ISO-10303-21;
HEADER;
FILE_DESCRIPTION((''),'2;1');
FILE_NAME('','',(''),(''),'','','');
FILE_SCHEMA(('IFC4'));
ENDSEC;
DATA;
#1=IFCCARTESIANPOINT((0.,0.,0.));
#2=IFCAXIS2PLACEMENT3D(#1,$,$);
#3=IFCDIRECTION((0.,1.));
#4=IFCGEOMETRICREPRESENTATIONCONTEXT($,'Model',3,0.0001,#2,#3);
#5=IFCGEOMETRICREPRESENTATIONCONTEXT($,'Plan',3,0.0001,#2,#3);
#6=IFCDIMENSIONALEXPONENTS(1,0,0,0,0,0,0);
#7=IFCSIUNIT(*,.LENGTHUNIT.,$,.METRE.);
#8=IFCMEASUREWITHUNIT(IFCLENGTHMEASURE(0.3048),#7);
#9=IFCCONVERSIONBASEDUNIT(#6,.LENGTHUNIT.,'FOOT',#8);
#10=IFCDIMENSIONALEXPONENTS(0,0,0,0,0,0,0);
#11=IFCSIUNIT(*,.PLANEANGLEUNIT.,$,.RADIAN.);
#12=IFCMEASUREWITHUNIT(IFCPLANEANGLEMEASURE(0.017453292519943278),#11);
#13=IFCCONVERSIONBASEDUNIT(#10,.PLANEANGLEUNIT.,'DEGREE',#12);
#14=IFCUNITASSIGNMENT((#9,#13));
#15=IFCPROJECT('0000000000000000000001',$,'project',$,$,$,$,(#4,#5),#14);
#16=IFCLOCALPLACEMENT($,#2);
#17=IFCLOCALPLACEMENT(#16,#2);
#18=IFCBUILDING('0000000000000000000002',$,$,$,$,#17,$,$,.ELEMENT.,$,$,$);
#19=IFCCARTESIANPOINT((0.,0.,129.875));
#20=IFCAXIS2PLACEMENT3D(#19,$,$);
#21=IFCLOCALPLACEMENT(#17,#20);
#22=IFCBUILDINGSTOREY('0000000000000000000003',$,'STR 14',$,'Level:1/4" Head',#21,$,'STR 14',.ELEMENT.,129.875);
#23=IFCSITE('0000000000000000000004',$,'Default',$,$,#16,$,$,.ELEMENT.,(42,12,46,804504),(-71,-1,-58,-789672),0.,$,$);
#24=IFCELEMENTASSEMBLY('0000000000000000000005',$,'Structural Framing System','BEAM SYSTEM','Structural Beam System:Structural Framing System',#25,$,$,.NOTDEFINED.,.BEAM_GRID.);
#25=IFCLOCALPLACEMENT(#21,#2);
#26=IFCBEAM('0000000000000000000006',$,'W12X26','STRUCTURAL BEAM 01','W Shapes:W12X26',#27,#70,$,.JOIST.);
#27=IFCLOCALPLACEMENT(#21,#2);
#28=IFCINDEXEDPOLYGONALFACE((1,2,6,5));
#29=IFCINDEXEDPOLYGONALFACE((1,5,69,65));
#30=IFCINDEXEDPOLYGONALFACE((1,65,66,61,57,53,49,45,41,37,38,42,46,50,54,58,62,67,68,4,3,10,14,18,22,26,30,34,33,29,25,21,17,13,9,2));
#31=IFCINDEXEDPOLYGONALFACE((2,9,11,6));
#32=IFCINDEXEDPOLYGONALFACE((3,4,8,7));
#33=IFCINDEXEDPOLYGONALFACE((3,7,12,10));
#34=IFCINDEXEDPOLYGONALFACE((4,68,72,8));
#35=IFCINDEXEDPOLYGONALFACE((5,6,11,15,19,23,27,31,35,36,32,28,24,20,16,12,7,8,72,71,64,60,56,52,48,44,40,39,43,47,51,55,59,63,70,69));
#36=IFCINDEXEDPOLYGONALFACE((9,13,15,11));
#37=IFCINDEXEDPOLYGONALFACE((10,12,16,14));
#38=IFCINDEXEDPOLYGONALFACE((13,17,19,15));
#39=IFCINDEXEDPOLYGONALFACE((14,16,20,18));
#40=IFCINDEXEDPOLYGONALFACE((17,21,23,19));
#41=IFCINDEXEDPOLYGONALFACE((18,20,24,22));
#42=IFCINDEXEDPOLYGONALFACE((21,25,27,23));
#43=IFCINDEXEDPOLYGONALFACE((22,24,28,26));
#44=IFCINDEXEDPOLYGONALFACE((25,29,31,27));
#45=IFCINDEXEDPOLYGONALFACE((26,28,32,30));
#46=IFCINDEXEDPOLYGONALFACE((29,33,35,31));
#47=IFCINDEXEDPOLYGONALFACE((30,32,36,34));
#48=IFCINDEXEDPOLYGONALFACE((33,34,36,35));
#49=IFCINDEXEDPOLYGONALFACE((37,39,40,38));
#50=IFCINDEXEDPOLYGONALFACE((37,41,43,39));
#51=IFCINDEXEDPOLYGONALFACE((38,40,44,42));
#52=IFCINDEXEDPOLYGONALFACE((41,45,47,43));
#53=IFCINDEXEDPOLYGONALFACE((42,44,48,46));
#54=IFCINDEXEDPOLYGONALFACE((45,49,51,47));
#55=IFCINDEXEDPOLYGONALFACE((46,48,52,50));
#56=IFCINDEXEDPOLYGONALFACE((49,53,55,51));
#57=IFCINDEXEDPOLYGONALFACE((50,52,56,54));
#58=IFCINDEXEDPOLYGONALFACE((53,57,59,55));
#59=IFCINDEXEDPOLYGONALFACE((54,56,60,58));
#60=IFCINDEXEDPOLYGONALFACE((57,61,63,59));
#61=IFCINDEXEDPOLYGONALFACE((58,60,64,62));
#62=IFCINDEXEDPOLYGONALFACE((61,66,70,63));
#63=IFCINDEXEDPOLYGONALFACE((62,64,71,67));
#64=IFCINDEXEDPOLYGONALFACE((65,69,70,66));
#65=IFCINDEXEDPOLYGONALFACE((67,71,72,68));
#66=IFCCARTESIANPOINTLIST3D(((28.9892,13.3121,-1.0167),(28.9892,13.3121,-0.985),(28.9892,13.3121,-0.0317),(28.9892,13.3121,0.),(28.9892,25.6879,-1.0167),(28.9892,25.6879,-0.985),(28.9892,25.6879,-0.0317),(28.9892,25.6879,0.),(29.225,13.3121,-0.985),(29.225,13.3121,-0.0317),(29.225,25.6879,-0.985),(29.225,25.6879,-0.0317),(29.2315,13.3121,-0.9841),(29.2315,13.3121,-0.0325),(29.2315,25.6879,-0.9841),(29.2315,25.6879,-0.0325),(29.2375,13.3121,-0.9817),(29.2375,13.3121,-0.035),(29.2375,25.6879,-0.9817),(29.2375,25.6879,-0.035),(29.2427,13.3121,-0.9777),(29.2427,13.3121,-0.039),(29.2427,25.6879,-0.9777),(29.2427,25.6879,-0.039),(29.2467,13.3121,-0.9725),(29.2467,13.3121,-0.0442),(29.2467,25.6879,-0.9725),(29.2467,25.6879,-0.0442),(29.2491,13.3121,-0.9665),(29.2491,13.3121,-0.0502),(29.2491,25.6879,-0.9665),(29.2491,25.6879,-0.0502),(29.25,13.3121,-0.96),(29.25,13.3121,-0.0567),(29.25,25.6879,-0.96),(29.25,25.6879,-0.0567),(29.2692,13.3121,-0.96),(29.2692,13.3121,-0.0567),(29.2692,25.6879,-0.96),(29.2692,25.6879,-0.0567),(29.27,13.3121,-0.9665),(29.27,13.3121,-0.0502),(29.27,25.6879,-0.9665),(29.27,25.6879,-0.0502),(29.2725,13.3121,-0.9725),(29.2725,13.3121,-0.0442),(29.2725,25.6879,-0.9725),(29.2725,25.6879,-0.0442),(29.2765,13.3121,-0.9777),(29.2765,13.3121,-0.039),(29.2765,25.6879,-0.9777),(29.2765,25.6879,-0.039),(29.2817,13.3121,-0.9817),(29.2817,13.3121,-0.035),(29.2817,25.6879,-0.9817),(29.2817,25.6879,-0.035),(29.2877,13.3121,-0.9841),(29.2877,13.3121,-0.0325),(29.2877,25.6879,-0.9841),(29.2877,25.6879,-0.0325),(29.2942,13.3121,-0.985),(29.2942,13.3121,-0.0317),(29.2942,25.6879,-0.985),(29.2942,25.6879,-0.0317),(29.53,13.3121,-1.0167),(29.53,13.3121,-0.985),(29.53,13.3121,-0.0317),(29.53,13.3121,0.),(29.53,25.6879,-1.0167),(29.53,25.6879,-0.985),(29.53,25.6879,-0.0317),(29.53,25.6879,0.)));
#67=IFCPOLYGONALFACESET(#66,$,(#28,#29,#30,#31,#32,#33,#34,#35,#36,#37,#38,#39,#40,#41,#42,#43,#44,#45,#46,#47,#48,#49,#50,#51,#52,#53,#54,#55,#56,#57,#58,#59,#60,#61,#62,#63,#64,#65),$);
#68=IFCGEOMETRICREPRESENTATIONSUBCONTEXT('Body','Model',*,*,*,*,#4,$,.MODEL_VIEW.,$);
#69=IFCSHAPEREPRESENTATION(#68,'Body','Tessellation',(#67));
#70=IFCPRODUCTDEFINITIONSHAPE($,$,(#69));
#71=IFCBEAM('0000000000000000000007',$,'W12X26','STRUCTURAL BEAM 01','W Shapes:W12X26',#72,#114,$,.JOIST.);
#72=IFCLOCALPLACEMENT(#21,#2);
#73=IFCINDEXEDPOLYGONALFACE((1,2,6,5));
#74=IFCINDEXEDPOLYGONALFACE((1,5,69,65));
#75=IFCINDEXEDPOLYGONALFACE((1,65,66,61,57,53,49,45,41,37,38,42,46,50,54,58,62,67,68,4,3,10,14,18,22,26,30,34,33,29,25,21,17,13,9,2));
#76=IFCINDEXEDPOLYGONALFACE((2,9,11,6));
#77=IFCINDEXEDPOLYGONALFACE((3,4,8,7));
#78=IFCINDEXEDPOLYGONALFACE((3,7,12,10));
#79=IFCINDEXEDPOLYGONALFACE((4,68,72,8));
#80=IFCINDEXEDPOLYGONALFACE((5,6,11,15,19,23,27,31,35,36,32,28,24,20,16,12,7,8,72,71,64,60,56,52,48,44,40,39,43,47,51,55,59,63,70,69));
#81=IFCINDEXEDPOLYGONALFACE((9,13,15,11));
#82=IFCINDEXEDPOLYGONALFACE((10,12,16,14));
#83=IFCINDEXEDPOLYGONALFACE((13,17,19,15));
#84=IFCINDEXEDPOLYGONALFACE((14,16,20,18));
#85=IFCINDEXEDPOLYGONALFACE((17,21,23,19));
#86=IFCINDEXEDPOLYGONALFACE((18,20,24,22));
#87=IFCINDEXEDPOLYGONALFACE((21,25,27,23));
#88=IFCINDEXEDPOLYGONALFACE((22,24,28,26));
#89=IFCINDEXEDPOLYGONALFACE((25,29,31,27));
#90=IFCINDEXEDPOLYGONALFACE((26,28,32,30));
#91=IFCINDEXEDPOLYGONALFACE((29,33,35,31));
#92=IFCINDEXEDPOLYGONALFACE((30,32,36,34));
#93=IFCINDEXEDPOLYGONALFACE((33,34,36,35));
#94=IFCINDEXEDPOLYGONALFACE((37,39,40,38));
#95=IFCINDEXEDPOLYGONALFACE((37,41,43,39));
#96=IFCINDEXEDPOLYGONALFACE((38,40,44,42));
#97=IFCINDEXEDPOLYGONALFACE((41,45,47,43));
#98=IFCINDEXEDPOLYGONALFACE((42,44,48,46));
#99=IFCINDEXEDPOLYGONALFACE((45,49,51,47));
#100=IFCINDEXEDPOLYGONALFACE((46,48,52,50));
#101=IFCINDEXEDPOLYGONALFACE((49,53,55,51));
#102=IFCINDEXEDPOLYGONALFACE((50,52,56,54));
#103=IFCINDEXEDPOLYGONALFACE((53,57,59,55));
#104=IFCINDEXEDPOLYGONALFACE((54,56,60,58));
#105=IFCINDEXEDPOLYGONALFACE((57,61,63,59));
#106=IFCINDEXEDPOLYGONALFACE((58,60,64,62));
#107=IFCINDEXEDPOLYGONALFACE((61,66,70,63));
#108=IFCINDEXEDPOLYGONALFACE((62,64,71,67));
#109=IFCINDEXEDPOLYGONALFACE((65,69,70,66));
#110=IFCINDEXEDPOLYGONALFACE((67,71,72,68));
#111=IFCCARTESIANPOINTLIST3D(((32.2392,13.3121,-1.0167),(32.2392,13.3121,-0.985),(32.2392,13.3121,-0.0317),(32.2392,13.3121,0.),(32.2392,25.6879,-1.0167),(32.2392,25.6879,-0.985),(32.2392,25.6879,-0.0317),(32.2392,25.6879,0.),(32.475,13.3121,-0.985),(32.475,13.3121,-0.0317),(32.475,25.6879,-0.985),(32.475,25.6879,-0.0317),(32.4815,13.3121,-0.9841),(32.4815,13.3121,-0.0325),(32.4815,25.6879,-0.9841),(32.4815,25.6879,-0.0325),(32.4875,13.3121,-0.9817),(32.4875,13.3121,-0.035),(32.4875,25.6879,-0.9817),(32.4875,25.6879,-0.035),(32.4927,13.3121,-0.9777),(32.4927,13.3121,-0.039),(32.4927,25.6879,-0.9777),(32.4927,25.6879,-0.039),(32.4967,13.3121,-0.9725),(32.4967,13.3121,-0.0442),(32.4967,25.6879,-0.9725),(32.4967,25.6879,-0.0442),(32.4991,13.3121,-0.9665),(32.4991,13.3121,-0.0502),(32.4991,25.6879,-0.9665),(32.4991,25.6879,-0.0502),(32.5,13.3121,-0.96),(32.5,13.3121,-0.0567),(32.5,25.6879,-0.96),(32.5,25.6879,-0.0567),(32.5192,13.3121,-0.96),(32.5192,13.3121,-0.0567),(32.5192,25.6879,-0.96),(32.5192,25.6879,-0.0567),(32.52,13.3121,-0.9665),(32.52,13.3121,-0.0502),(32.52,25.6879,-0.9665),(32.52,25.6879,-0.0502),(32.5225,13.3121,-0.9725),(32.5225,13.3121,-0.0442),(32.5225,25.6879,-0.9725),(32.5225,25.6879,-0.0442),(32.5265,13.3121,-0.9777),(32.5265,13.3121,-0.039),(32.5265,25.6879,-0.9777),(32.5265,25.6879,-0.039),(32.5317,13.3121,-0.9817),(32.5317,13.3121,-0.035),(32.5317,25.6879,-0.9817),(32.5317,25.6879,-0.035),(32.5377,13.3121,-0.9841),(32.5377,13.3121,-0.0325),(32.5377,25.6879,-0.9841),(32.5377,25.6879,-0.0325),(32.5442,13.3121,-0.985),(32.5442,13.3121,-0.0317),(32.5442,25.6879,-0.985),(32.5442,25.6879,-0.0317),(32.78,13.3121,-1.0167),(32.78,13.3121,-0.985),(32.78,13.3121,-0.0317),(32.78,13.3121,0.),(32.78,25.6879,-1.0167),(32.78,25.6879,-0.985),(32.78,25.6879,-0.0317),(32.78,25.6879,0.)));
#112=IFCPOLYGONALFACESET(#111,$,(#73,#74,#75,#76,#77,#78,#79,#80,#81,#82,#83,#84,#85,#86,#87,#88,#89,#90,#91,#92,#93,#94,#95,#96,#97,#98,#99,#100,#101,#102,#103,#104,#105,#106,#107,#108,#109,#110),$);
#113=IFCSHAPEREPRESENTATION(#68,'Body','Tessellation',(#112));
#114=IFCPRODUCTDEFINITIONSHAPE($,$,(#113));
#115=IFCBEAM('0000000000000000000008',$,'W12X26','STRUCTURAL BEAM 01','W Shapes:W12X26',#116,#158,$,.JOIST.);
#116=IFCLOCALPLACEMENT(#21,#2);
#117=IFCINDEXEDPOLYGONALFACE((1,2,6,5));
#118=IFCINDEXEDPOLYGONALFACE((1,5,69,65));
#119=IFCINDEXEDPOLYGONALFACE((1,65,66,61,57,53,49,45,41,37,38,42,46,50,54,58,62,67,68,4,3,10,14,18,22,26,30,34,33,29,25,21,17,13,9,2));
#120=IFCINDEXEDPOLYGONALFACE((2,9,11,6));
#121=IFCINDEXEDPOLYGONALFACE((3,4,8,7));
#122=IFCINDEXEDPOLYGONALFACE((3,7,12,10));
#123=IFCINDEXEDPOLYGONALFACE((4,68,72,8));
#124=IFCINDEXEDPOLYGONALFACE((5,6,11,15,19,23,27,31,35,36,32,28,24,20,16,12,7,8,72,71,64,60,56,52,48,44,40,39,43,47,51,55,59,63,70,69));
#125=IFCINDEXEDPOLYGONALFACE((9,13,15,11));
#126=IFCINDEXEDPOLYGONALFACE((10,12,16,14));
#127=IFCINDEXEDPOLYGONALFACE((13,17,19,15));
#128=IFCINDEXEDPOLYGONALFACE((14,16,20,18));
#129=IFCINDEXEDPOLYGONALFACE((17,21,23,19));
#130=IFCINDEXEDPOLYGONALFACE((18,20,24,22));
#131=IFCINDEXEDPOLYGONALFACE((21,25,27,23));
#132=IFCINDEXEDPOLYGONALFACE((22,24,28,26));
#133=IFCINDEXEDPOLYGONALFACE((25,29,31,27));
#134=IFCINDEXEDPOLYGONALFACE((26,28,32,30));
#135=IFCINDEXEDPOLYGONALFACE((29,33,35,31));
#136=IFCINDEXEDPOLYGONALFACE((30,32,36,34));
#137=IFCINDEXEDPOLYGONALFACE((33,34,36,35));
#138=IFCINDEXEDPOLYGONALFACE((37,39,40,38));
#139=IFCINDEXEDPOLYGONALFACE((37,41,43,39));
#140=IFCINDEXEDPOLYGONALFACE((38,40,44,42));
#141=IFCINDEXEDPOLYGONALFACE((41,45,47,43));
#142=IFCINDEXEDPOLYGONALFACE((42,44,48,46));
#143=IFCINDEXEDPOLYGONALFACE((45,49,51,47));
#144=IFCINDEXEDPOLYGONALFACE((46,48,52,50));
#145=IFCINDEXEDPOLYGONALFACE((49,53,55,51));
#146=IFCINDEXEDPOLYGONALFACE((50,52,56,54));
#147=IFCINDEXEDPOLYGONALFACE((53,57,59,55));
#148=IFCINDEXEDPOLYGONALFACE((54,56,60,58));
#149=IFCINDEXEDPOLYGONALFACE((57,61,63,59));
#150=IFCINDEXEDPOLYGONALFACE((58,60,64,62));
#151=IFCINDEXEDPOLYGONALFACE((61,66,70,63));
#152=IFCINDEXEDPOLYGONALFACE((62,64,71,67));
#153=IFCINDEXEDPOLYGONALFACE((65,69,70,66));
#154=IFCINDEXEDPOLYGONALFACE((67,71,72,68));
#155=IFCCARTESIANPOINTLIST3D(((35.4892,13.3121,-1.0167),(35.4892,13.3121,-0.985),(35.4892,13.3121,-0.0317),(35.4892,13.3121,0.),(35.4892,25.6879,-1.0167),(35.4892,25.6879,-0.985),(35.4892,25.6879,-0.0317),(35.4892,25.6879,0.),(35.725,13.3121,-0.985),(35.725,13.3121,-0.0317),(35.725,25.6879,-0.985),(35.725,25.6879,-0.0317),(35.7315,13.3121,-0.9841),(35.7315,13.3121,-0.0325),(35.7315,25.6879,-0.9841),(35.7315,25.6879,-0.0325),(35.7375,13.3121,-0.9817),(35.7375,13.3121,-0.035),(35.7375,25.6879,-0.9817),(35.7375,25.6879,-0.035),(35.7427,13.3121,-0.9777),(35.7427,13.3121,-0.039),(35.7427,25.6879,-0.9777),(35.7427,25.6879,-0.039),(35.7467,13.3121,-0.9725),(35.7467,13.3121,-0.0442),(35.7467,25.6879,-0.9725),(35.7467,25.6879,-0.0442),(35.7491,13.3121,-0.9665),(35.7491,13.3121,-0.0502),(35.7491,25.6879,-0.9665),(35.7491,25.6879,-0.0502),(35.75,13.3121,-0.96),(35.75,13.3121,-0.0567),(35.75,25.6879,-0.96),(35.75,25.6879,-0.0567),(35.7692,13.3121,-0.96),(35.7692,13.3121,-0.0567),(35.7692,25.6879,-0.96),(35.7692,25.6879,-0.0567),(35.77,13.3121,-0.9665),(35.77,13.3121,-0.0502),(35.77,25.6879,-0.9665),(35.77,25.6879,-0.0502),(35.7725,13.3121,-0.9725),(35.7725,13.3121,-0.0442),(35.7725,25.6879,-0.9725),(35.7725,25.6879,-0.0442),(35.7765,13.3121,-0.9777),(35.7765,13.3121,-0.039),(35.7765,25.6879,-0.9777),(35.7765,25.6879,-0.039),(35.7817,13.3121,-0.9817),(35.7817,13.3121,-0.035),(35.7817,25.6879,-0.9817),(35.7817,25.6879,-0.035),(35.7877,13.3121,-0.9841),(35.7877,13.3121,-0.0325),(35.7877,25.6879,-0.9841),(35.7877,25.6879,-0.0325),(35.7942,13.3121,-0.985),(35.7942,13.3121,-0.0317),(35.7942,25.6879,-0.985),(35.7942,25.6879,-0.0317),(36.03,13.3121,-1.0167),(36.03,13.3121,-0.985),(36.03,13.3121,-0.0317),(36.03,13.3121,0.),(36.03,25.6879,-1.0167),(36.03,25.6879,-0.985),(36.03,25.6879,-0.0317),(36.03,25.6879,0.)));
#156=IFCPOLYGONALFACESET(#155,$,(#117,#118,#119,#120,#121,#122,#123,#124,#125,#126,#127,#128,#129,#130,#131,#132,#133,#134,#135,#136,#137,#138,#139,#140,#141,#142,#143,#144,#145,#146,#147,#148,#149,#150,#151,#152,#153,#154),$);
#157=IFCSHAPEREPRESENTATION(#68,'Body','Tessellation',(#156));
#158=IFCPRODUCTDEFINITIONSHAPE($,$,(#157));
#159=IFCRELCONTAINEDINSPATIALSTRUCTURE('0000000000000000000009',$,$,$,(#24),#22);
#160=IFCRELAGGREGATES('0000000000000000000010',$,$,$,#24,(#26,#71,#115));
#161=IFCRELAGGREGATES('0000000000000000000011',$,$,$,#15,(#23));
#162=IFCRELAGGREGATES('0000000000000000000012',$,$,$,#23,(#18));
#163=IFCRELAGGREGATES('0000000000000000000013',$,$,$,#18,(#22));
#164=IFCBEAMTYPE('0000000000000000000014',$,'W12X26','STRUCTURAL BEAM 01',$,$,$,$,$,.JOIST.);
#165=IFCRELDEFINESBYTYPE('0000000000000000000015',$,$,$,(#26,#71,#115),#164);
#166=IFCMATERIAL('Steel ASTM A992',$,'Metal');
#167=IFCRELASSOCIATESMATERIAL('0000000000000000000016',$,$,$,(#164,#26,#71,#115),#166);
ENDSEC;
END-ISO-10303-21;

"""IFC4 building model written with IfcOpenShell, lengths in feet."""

from ifc_helpers import new_model, entity, si_unit, converted_unit, direction, frame, origin, place, context, subcontext, project, spatial, line, arc, indexed_curve, outline, extrude, source, transform, mapped, material, type_object, type_shapes, element, aggregate, save


model = new_model("IFC4")

# Units and contexts
model_context = context("Model", 3, precision=0.0001, world=origin(), true_north=direction((0.0, 1.0)))
plan_context = context("Plan", 3, precision=0.0001, world=origin(), true_north=direction((0.0, 1.0)))
body_context = subcontext(model_context, "Body", "Model", "MODEL_VIEW")
ifc_project = project(units=[converted_unit("LENGTHUNIT", "FOOT", entity("IfcLengthMeasure", 0.3048), si_unit("LENGTHUNIT", "METRE"), dimensions=[1, 0, 0, 0, 0, 0, 0]), converted_unit("PLANEANGLEUNIT", "DEGREE", entity("IfcPlaneAngleMeasure", 0.017453292519943278), si_unit("PLANEANGLEUNIT", "RADIAN"), dimensions=[0, 0, 0, 0, 0, 0, 0])], contexts=[model_context, plan_context])

# Site, building, storey
site_placement = place(None, origin())
site = spatial("IfcSite", under=ifc_project, at=site_placement, Name="Default", CompositionType="ELEMENT", RefLatitude=(42, 12, 46, 804504), RefLongitude=(-71, -1, -58, -789672), RefElevation=0.0)
building_placement = place(site_placement, origin())
building = spatial("IfcBuilding", under=site, at=building_placement, CompositionType="ELEMENT")
storey_placement = place(building_placement, frame((0.0, 0.0, 129.875)))
storey = spatial("IfcBuildingStorey", under=building, at=storey_placement, Name="STR 14", ObjectType="Level:1/4\" Head", LongName="STR 14", CompositionType="ELEMENT", Elevation=129.875)

# Shared definitions
ifc_material = material(Name="Steel ASTM A992", Category="Metal")

# Element assembly, beams
beam_type_1 = type_object("IfcBeamType", Name="W12X26", Description="STRUCTURAL BEAM 01", PredefinedType="JOIST", material=ifc_material)
shared_shape_1 = source(origin(), body_context, "Body", "SweptSolid", [
    extrude(outline(indexed_curve([(-0.2704, -0.4767), (-0.2704, -0.5083), (0.2704, -0.5083), (0.2704, -0.4767), (0.0346, -0.4767), (0.0169, -0.4693), (0.0096, -0.4517), (0.0096, 0.4517), (0.0169, 0.4693), (0.0346, 0.4767), (0.2704, 0.4767), (0.2704, 0.5083), (-0.2704, 0.5083), (-0.2704, 0.4767), (-0.0346, 0.4767), (-0.0169, 0.4693), (-0.0096, 0.4517), (-0.0096, -0.4517), (-0.0169, -0.4693), (-0.0346, -0.4767)], segments=[line(1, 2, 3, 4, 5), arc(5, 6, 7), line(7, 8), arc(8, 9, 10), line(10, 11, 12, 13, 14, 15), arc(15, 16, 17), line(17, 18), arc(18, 19, 20), line(20, 1)], self_intersect=False)), frame((-6.1879, 0.0, 0.0), z_axis=(-1.0, 0.0, 0.0), x_axis=(0.0, -1.0, 0.0)), (0.0, 0.0, -1.0), 12.3758),
])
type_shapes(beam_type_1, [shared_shape_1])
assembly_1_placement = place(storey_placement, origin())
assembly_1 = element("IfcElementAssembly", 1, at=assembly_1_placement, inside=storey, Name="Structural Framing System", Description="BEAM SYSTEM", ObjectType="Structural Beam System:Structural Framing System", AssemblyPlace="NOTDEFINED", PredefinedType="BEAM_GRID")
beam_1_placement = place(assembly_1_placement, frame((29.2596, 19.5, -0.5083), z_axis=(0.0, 0.0, 1.0), x_axis=(0.0, 1.0, 0.0)))
beam_1 = element("IfcBeam", 2, at=beam_1_placement, type_object=beam_type_1, material=ifc_material, Name="W12X26", Description="STRUCTURAL BEAM 01", ObjectType="W Shapes:W12X26", PredefinedType="JOIST", context=body_context, shape_type="MappedRepresentation", body=[
    mapped(shared_shape_1, transform((0.0, 0.0, 0.0), scale=1.0)),
])
beam_2_placement = place(assembly_1_placement, frame((32.5096, 19.5, -0.5083), z_axis=(0.0, 0.0, 1.0), x_axis=(0.0, 1.0, 0.0)))
beam_2 = element("IfcBeam", 3, at=beam_2_placement, type_object=beam_type_1, material=ifc_material, Name="W12X26", Description="STRUCTURAL BEAM 01", ObjectType="W Shapes:W12X26", PredefinedType="JOIST", context=body_context, shape_type="MappedRepresentation", body=[
    mapped(shared_shape_1, transform((0.0, 0.0, 0.0), scale=1.0)),
])
beam_3_placement = place(assembly_1_placement, frame((35.7596, 19.5, -0.5083), z_axis=(0.0, 0.0, 1.0), x_axis=(0.0, 1.0, 0.0)))
beam_3 = element("IfcBeam", 4, at=beam_3_placement, type_object=beam_type_1, material=ifc_material, Name="W12X26", Description="STRUCTURAL BEAM 01", ObjectType="W Shapes:W12X26", PredefinedType="JOIST", context=body_context, shape_type="MappedRepresentation", body=[
    mapped(shared_shape_1, transform((0.0, 0.0, 0.0), scale=1.0)),
])
aggregate(assembly_1, [beam_1, beam_2, beam_3])

save(model, "model.ifc")
